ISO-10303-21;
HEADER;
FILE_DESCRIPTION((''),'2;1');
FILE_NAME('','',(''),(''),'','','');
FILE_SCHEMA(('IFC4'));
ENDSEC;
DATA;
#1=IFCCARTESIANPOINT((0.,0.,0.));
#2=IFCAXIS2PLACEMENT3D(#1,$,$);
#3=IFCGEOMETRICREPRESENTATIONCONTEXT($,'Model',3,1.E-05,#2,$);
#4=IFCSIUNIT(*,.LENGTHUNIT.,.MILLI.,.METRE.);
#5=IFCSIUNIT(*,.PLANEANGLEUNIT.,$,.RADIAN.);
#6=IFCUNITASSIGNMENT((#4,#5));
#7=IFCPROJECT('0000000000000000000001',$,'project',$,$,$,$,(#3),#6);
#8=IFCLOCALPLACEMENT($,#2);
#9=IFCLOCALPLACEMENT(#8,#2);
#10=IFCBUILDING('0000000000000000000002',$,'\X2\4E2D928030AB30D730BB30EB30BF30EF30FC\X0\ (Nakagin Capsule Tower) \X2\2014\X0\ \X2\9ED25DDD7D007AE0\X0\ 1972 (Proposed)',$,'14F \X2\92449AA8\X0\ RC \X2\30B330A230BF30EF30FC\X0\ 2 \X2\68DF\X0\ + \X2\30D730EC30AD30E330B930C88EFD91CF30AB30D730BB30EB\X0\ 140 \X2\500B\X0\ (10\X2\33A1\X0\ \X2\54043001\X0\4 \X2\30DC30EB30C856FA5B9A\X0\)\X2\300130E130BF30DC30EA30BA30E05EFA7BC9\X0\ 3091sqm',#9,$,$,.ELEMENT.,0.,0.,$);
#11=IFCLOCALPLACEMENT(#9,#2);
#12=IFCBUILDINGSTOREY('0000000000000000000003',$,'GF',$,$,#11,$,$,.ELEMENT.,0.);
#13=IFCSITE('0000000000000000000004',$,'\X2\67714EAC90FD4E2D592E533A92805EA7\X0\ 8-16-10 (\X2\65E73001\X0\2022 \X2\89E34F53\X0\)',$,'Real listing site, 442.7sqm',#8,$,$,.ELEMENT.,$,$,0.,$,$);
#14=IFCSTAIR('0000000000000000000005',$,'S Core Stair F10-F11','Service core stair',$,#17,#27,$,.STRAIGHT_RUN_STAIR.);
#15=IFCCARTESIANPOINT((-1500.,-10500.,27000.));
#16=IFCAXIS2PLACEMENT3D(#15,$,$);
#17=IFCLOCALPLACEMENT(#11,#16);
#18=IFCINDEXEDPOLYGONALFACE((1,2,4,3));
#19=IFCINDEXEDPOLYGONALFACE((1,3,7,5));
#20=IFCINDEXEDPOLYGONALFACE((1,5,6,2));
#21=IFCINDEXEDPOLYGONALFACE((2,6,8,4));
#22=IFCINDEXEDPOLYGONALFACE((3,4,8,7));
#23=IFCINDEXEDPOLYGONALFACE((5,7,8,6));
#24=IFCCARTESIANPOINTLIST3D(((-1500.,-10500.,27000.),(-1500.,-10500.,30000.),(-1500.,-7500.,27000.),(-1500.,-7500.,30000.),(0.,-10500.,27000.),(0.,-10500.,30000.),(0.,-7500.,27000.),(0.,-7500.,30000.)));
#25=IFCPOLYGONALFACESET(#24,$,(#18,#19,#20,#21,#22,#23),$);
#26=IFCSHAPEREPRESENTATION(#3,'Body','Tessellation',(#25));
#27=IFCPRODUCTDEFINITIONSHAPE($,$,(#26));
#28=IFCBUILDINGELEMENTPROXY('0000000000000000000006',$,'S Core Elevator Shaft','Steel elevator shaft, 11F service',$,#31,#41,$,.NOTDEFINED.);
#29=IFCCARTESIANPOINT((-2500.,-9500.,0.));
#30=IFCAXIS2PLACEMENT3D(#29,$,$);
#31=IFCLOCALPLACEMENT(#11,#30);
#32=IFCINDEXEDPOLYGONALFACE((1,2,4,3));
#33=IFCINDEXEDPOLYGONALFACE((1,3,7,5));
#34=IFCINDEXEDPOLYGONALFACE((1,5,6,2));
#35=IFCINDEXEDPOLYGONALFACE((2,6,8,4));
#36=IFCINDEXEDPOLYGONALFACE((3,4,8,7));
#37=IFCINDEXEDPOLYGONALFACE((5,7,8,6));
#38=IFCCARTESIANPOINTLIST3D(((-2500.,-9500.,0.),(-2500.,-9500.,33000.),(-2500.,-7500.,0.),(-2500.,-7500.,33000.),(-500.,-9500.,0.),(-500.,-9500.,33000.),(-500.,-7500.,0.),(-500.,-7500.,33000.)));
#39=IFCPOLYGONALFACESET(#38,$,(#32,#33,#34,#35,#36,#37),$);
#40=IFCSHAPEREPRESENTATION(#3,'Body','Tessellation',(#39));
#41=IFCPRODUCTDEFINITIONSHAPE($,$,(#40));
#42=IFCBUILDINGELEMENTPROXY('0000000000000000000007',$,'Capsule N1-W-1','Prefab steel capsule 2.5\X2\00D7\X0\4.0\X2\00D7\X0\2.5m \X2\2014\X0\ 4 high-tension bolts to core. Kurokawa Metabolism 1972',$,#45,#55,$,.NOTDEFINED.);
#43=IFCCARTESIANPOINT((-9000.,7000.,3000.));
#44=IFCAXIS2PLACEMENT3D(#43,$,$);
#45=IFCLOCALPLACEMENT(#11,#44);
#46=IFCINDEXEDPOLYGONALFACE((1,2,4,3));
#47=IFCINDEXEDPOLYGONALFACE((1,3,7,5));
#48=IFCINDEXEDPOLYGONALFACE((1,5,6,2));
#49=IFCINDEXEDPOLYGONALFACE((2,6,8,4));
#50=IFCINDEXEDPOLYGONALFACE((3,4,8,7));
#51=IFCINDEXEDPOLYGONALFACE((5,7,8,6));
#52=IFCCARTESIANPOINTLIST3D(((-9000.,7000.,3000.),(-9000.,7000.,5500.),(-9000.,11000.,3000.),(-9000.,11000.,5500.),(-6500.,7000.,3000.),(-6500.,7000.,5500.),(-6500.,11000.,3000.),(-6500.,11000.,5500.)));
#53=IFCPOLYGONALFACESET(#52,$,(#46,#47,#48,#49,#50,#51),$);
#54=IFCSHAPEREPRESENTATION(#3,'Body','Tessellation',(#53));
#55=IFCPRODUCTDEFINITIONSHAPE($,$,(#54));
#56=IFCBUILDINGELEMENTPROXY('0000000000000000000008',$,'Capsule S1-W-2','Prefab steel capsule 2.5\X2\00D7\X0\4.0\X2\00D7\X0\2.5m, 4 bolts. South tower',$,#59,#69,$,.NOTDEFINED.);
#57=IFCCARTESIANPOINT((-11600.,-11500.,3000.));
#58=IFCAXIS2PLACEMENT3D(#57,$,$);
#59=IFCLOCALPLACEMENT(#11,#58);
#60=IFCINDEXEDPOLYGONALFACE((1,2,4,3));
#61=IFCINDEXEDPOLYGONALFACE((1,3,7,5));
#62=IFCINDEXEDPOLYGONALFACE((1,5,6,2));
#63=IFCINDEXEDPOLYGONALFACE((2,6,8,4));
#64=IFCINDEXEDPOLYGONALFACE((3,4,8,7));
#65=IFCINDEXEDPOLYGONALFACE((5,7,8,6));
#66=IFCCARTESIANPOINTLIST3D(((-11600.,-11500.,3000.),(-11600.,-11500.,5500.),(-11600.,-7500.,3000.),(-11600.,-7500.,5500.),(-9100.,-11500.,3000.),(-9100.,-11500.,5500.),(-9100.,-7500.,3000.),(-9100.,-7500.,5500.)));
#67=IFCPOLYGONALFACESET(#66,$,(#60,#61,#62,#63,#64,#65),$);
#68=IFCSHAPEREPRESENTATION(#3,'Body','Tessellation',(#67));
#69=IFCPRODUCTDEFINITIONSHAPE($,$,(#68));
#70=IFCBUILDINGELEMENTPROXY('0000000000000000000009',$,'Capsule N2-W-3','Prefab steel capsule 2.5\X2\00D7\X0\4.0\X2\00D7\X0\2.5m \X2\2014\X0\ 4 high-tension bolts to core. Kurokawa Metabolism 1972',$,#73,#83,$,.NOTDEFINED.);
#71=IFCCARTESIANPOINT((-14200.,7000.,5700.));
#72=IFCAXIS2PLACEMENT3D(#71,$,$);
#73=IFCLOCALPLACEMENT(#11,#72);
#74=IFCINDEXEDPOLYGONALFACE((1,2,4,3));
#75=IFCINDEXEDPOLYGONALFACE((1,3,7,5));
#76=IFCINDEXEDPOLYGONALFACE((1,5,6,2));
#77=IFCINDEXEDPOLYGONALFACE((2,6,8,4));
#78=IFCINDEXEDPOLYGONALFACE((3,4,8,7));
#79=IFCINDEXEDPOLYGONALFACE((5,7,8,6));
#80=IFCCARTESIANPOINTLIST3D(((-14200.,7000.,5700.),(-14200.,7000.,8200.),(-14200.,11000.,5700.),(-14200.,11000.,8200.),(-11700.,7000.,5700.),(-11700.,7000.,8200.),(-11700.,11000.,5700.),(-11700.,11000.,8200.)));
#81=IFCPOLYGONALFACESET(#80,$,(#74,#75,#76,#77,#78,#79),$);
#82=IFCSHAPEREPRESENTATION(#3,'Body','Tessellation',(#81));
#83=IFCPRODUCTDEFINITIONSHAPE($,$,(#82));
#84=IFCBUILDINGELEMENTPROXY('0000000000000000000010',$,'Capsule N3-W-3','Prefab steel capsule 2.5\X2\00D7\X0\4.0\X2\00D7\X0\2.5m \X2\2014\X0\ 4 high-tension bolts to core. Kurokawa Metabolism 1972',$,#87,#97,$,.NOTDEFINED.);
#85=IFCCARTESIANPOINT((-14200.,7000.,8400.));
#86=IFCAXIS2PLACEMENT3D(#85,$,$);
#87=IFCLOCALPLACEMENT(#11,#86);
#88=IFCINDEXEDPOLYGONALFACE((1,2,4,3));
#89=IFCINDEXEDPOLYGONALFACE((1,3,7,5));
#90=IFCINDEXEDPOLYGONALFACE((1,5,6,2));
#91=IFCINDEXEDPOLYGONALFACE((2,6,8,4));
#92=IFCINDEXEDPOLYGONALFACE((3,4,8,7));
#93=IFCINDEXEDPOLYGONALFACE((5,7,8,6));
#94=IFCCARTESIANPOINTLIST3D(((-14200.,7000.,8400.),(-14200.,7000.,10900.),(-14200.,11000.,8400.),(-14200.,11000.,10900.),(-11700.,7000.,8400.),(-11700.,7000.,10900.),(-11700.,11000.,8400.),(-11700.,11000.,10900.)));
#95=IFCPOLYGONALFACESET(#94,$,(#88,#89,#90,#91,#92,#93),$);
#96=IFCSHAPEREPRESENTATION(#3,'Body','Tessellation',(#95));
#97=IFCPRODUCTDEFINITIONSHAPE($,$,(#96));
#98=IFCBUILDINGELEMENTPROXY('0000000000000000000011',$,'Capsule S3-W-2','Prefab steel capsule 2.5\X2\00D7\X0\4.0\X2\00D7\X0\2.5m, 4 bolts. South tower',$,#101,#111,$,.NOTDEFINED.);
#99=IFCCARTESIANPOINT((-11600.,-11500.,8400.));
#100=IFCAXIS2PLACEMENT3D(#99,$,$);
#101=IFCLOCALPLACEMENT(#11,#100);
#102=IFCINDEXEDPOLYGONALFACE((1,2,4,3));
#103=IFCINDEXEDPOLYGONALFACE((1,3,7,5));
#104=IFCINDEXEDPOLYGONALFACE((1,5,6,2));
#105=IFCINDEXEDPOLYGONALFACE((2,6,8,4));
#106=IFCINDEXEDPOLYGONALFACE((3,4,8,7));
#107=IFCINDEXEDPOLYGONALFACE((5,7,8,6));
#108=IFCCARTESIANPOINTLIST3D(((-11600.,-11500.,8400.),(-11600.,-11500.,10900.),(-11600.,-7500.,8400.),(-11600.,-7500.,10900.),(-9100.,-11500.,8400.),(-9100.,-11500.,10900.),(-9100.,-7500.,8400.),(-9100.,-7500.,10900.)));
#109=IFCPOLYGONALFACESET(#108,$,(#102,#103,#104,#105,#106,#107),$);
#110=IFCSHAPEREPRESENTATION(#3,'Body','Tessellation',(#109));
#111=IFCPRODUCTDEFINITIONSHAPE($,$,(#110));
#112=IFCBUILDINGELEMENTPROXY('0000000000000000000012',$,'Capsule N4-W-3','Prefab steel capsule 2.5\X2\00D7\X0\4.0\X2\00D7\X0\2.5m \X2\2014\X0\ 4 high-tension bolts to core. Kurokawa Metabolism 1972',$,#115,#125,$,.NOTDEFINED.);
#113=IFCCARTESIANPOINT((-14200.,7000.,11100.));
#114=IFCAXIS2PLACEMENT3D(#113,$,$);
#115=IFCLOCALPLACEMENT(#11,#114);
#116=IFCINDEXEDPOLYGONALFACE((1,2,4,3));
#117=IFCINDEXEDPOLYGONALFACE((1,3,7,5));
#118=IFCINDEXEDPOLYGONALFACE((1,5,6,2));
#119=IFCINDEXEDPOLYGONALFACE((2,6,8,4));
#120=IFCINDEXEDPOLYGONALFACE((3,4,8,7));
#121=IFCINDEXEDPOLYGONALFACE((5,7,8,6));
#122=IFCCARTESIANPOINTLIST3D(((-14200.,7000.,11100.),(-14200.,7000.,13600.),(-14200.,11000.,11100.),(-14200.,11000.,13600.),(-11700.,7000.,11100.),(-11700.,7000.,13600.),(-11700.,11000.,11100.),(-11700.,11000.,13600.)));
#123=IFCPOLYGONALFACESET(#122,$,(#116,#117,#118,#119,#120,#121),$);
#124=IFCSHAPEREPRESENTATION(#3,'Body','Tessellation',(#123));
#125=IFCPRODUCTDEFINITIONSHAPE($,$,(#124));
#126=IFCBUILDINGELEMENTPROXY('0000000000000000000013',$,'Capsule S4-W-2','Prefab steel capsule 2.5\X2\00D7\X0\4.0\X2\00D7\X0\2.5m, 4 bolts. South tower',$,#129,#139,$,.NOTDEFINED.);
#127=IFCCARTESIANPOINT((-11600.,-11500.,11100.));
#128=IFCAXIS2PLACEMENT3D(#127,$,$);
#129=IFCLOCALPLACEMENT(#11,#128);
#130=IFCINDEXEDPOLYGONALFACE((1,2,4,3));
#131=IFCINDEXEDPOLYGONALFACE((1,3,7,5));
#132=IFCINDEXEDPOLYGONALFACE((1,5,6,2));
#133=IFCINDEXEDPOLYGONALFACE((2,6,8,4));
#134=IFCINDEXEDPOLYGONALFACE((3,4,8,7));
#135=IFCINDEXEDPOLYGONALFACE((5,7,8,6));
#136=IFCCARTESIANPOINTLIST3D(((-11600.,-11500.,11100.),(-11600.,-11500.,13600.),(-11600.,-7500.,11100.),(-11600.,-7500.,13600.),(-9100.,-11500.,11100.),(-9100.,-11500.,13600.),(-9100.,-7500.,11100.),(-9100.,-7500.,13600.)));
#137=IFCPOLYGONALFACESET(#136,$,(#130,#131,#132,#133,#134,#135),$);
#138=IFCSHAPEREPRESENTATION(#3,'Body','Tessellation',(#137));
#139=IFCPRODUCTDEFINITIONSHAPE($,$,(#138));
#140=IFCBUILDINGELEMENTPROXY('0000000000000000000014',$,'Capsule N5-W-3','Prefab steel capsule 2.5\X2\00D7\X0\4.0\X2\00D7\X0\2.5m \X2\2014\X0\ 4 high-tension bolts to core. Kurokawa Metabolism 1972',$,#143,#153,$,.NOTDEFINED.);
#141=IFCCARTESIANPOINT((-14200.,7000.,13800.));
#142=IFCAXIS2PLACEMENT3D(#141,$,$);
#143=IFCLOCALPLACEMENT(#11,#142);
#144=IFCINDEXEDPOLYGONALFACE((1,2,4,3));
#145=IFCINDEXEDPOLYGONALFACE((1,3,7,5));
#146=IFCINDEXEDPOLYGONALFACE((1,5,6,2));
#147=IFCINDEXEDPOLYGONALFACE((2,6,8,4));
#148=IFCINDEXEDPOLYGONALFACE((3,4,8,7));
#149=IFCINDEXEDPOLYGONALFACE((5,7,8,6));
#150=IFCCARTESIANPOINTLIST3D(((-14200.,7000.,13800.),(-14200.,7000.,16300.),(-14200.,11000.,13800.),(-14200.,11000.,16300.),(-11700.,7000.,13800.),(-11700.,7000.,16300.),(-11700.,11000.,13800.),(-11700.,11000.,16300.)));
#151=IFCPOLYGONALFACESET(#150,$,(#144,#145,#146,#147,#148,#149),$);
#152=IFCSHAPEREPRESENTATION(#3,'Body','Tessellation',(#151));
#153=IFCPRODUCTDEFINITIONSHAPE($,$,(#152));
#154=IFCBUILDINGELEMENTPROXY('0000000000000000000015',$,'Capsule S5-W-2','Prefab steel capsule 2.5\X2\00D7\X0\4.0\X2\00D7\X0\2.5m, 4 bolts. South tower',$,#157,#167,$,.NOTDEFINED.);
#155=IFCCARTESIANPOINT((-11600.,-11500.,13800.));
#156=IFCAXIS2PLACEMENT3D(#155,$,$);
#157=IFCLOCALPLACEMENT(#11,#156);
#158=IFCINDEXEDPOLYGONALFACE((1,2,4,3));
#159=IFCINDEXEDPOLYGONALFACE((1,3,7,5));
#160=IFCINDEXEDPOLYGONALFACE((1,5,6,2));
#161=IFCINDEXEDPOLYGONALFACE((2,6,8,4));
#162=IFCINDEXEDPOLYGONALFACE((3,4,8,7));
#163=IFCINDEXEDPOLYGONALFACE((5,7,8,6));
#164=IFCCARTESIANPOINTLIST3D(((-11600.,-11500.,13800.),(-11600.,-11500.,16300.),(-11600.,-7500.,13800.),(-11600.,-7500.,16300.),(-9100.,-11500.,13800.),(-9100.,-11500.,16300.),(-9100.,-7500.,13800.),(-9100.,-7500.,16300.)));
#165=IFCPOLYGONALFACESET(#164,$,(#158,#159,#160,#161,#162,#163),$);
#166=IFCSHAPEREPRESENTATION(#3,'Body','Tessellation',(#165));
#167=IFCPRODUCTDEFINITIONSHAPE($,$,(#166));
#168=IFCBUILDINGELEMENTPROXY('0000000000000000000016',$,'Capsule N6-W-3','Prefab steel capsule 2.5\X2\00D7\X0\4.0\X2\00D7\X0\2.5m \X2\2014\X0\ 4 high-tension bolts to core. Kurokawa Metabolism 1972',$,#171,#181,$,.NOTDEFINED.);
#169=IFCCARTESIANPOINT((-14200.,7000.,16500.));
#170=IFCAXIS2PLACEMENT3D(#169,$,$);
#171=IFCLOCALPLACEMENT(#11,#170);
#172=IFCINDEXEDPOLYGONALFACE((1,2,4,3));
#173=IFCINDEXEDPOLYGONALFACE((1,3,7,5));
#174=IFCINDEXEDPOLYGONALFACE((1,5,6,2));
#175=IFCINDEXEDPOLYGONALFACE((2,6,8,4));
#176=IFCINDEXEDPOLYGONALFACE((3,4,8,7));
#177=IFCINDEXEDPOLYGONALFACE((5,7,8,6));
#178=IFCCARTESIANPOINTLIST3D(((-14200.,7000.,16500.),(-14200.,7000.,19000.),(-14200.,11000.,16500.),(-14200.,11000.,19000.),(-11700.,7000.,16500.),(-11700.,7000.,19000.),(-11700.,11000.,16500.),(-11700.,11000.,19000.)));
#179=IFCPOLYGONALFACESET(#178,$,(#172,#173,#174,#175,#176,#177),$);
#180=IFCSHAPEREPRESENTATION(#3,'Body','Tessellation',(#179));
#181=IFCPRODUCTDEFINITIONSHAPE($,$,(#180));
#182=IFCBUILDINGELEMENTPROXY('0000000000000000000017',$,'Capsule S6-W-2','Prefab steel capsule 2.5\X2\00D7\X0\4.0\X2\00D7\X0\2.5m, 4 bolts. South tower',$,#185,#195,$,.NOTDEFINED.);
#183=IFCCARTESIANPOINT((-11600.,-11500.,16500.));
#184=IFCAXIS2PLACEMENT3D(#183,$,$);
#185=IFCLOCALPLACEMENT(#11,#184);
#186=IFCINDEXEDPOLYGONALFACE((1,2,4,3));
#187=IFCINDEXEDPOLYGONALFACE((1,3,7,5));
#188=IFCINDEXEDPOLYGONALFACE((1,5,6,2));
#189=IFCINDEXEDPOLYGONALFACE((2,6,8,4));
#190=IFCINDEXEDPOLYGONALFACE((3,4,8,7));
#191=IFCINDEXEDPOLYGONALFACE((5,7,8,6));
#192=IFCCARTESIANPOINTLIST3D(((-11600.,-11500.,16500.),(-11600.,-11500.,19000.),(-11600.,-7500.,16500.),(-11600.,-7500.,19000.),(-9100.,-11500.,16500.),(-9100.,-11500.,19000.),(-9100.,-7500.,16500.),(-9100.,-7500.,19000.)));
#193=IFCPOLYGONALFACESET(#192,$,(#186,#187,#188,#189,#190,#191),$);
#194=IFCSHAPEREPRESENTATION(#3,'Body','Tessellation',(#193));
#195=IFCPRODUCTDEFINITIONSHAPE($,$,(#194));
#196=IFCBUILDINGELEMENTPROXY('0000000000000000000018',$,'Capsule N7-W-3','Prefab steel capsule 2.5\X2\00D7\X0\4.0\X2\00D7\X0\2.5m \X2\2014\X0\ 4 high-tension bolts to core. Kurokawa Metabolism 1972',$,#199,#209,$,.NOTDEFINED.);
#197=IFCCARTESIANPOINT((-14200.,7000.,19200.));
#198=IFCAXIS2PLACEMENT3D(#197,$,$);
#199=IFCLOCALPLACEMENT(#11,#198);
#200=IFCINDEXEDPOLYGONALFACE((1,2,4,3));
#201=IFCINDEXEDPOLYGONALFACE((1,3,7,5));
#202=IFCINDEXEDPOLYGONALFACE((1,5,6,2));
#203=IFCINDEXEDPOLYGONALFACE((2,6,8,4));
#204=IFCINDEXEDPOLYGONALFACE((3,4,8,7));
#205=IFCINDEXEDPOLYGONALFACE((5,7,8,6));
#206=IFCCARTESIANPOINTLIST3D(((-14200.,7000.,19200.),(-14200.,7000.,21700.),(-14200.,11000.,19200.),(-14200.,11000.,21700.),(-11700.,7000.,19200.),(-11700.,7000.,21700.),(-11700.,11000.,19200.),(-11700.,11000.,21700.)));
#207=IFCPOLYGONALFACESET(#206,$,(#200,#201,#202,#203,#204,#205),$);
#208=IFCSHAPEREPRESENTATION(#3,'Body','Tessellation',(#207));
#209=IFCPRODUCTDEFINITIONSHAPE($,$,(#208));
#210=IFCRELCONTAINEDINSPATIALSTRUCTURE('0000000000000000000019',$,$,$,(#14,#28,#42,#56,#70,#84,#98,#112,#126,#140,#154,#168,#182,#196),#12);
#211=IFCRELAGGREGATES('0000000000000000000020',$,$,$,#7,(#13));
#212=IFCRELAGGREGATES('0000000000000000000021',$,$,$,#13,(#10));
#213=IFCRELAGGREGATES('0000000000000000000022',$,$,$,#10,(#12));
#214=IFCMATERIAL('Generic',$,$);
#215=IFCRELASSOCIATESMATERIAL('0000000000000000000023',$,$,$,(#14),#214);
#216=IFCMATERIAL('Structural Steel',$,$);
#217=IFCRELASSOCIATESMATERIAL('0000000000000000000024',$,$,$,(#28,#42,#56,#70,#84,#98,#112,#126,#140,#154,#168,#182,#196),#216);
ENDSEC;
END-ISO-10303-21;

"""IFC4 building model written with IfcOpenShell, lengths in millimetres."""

from ifc_helpers import new_model, si_unit, frame, frame_2d, origin, place, context, project, spatial, rectangle, extrude, material, element, save


model = new_model("IFC4")

# Units and contexts
model_context = context("Model", 3, precision=1e-05, world=origin())
ifc_project = project(units=[si_unit("LENGTHUNIT", "METRE", prefix="MILLI"), si_unit("PLANEANGLEUNIT", "RADIAN")], contexts=[model_context])

# Site, building, storey
site_placement = place(None, origin())
site = spatial("IfcSite", under=ifc_project, at=site_placement, Name="東京都中央区銀座 8-16-10 (旧、2022 解体)", ObjectType="Real listing site, 442.7sqm", CompositionType="ELEMENT", RefElevation=0.0)
building_placement = place(site_placement, origin())
building = spatial("IfcBuilding", under=site, at=building_placement, Name="中銀カプセルタワー (Nakagin Capsule Tower) — 黒川紀章 1972 (Proposed)", ObjectType="14F 鉄骨 RC コアタワー 2 棟 + プレキャスト軽量カプセル 140 個 (10㎡ 各、4 ボルト固定)、メタボリズム建築 3091sqm", CompositionType="ELEMENT", ElevationOfRefHeight=0.0, ElevationOfTerrain=0.0)
storey_placement = place(building_placement, origin())
storey = spatial("IfcBuildingStorey", under=building, at=storey_placement, Name="GF", CompositionType="ELEMENT", Elevation=0.0)

# Shared definitions
ifc_material_1 = material(Name="Structural Steel")

# Stair
ifc_material_2 = material(Name="Generic")
stair_1_placement = place(storey_placement, frame((-1500.0, -10500.0, 27000.0)))
element("IfcStair", 1, at=stair_1_placement, inside=storey, material=ifc_material_2, Name="S Core Stair F10-F11", Description="Service core stair", PredefinedType="STRAIGHT_RUN_STAIR", context=model_context, shape_type="SweptSolid", body=[
    extrude(rectangle(XDim=1500.0, YDim=3000.0, at=frame_2d((750.0, 1500.0))), frame((-1500.0, -10500.0, 27000.0)), (0.0, 0.0, 1.0), 3000.0),
])

# Building element proxies
proxy_1_placement = place(storey_placement, frame((-2500.0, -9500.0, 0.0)))
element("IfcBuildingElementProxy", 2, at=proxy_1_placement, inside=storey, material=ifc_material_1, Name="S Core Elevator Shaft", Description="Steel elevator shaft, 11F service", PredefinedType="NOTDEFINED", context=model_context, shape_type="SweptSolid", body=[
    extrude(rectangle(XDim=2000.0, YDim=2000.0, at=frame_2d((1000.0, 1000.0))), frame((-2500.0, -9500.0, 0.0)), (0.0, 0.0, 1.0), 33000.0),
])
proxy_2_placement = place(storey_placement, frame((-9000.0, 7000.0, 3000.0)))
element("IfcBuildingElementProxy", 3, at=proxy_2_placement, inside=storey, material=ifc_material_1, Name="Capsule N1-W-1", Description="Prefab steel capsule 2.5×4.0×2.5m — 4 high-tension bolts to core. Kurokawa Metabolism 1972", PredefinedType="NOTDEFINED", context=model_context, shape_type="SweptSolid", body=[
    extrude(rectangle(XDim=2500.0, YDim=4000.0, at=frame_2d((1250.0, 2000.0))), frame((-9000.0, 7000.0, 3000.0)), (0.0, 0.0, 1.0), 2500.0),
])
proxy_3_placement = place(storey_placement, frame((-11600.0, -11500.0, 3000.0)))
element("IfcBuildingElementProxy", 4, at=proxy_3_placement, inside=storey, material=ifc_material_1, Name="Capsule S1-W-2", Description="Prefab steel capsule 2.5×4.0×2.5m, 4 bolts. South tower", PredefinedType="NOTDEFINED", context=model_context, shape_type="SweptSolid", body=[
    extrude(rectangle(XDim=2500.0, YDim=4000.0, at=frame_2d((1250.0, 2000.0))), frame((-11600.0, -11500.0, 3000.0)), (0.0, 0.0, 1.0), 2500.0),
])
proxy_4_placement = place(storey_placement, frame((-14200.0, 7000.0, 5700.0)))
element("IfcBuildingElementProxy", 5, at=proxy_4_placement, inside=storey, material=ifc_material_1, Name="Capsule N2-W-3", Description="Prefab steel capsule 2.5×4.0×2.5m — 4 high-tension bolts to core. Kurokawa Metabolism 1972", PredefinedType="NOTDEFINED", context=model_context, shape_type="SweptSolid", body=[
    extrude(rectangle(XDim=2500.0, YDim=4000.0, at=frame_2d((1250.0, 2000.0))), frame((-14200.0, 7000.0, 5700.0)), (0.0, 0.0, 1.0), 2500.0),
])
proxy_5_placement = place(storey_placement, frame((-14200.0, 7000.0, 8400.0)))
element("IfcBuildingElementProxy", 6, at=proxy_5_placement, inside=storey, material=ifc_material_1, Name="Capsule N3-W-3", Description="Prefab steel capsule 2.5×4.0×2.5m — 4 high-tension bolts to core. Kurokawa Metabolism 1972", PredefinedType="NOTDEFINED", context=model_context, shape_type="SweptSolid", body=[
    extrude(rectangle(XDim=2500.0, YDim=4000.0, at=frame_2d((1250.0, 2000.0))), frame((-14200.0, 7000.0, 8400.0)), (0.0, 0.0, 1.0), 2500.0),
])
proxy_6_placement = place(storey_placement, frame((-11600.0, -11500.0, 8400.0)))
element("IfcBuildingElementProxy", 7, at=proxy_6_placement, inside=storey, material=ifc_material_1, Name="Capsule S3-W-2", Description="Prefab steel capsule 2.5×4.0×2.5m, 4 bolts. South tower", PredefinedType="NOTDEFINED", context=model_context, shape_type="SweptSolid", body=[
    extrude(rectangle(XDim=2500.0, YDim=4000.0, at=frame_2d((1250.0, 2000.0))), frame((-11600.0, -11500.0, 8400.0)), (0.0, 0.0, 1.0), 2500.0),
])
proxy_7_placement = place(storey_placement, frame((-14200.0, 7000.0, 11100.0)))
element("IfcBuildingElementProxy", 8, at=proxy_7_placement, inside=storey, material=ifc_material_1, Name="Capsule N4-W-3", Description="Prefab steel capsule 2.5×4.0×2.5m — 4 high-tension bolts to core. Kurokawa Metabolism 1972", PredefinedType="NOTDEFINED", context=model_context, shape_type="SweptSolid", body=[
    extrude(rectangle(XDim=2500.0, YDim=4000.0, at=frame_2d((1250.0, 2000.0))), frame((-14200.0, 7000.0, 11100.0)), (0.0, 0.0, 1.0), 2500.0),
])
proxy_8_placement = place(storey_placement, frame((-11600.0, -11500.0, 11100.0)))
element("IfcBuildingElementProxy", 9, at=proxy_8_placement, inside=storey, material=ifc_material_1, Name="Capsule S4-W-2", Description="Prefab steel capsule 2.5×4.0×2.5m, 4 bolts. South tower", PredefinedType="NOTDEFINED", context=model_context, shape_type="SweptSolid", body=[
    extrude(rectangle(XDim=2500.0, YDim=4000.0, at=frame_2d((1250.0, 2000.0))), frame((-11600.0, -11500.0, 11100.0)), (0.0, 0.0, 1.0), 2500.0),
])
proxy_9_placement = place(storey_placement, frame((-14200.0, 7000.0, 13800.0)))
element("IfcBuildingElementProxy", 10, at=proxy_9_placement, inside=storey, material=ifc_material_1, Name="Capsule N5-W-3", Description="Prefab steel capsule 2.5×4.0×2.5m — 4 high-tension bolts to core. Kurokawa Metabolism 1972", PredefinedType="NOTDEFINED", context=model_context, shape_type="SweptSolid", body=[
    extrude(rectangle(XDim=2500.0, YDim=4000.0, at=frame_2d((1250.0, 2000.0))), frame((-14200.0, 7000.0, 13800.0)), (0.0, 0.0, 1.0), 2500.0),
])
proxy_10_placement = place(storey_placement, frame((-11600.0, -11500.0, 13800.0)))
element("IfcBuildingElementProxy", 11, at=proxy_10_placement, inside=storey, material=ifc_material_1, Name="Capsule S5-W-2", Description="Prefab steel capsule 2.5×4.0×2.5m, 4 bolts. South tower", PredefinedType="NOTDEFINED", context=model_context, shape_type="SweptSolid", body=[
    extrude(rectangle(XDim=2500.0, YDim=4000.0, at=frame_2d((1250.0, 2000.0))), frame((-11600.0, -11500.0, 13800.0)), (0.0, 0.0, 1.0), 2500.0),
])
proxy_11_placement = place(storey_placement, frame((-14200.0, 7000.0, 16500.0)))
element("IfcBuildingElementProxy", 12, at=proxy_11_placement, inside=storey, material=ifc_material_1, Name="Capsule N6-W-3", Description="Prefab steel capsule 2.5×4.0×2.5m — 4 high-tension bolts to core. Kurokawa Metabolism 1972", PredefinedType="NOTDEFINED", context=model_context, shape_type="SweptSolid", body=[
    extrude(rectangle(XDim=2500.0, YDim=4000.0, at=frame_2d((1250.0, 2000.0))), frame((-14200.0, 7000.0, 16500.0)), (0.0, 0.0, 1.0), 2500.0),
])
proxy_12_placement = place(storey_placement, frame((-11600.0, -11500.0, 16500.0)))
element("IfcBuildingElementProxy", 13, at=proxy_12_placement, inside=storey, material=ifc_material_1, Name="Capsule S6-W-2", Description="Prefab steel capsule 2.5×4.0×2.5m, 4 bolts. South tower", PredefinedType="NOTDEFINED", context=model_context, shape_type="SweptSolid", body=[
    extrude(rectangle(XDim=2500.0, YDim=4000.0, at=frame_2d((1250.0, 2000.0))), frame((-11600.0, -11500.0, 16500.0)), (0.0, 0.0, 1.0), 2500.0),
])
proxy_13_placement = place(storey_placement, frame((-14200.0, 7000.0, 19200.0)))
element("IfcBuildingElementProxy", 14, at=proxy_13_placement, inside=storey, material=ifc_material_1, Name="Capsule N7-W-3", Description="Prefab steel capsule 2.5×4.0×2.5m — 4 high-tension bolts to core. Kurokawa Metabolism 1972", PredefinedType="NOTDEFINED", context=model_context, shape_type="SweptSolid", body=[
    extrude(rectangle(XDim=2500.0, YDim=4000.0, at=frame_2d((1250.0, 2000.0))), frame((-14200.0, 7000.0, 19200.0)), (0.0, 0.0, 1.0), 2500.0),
])

save(model, "model.ifc")
